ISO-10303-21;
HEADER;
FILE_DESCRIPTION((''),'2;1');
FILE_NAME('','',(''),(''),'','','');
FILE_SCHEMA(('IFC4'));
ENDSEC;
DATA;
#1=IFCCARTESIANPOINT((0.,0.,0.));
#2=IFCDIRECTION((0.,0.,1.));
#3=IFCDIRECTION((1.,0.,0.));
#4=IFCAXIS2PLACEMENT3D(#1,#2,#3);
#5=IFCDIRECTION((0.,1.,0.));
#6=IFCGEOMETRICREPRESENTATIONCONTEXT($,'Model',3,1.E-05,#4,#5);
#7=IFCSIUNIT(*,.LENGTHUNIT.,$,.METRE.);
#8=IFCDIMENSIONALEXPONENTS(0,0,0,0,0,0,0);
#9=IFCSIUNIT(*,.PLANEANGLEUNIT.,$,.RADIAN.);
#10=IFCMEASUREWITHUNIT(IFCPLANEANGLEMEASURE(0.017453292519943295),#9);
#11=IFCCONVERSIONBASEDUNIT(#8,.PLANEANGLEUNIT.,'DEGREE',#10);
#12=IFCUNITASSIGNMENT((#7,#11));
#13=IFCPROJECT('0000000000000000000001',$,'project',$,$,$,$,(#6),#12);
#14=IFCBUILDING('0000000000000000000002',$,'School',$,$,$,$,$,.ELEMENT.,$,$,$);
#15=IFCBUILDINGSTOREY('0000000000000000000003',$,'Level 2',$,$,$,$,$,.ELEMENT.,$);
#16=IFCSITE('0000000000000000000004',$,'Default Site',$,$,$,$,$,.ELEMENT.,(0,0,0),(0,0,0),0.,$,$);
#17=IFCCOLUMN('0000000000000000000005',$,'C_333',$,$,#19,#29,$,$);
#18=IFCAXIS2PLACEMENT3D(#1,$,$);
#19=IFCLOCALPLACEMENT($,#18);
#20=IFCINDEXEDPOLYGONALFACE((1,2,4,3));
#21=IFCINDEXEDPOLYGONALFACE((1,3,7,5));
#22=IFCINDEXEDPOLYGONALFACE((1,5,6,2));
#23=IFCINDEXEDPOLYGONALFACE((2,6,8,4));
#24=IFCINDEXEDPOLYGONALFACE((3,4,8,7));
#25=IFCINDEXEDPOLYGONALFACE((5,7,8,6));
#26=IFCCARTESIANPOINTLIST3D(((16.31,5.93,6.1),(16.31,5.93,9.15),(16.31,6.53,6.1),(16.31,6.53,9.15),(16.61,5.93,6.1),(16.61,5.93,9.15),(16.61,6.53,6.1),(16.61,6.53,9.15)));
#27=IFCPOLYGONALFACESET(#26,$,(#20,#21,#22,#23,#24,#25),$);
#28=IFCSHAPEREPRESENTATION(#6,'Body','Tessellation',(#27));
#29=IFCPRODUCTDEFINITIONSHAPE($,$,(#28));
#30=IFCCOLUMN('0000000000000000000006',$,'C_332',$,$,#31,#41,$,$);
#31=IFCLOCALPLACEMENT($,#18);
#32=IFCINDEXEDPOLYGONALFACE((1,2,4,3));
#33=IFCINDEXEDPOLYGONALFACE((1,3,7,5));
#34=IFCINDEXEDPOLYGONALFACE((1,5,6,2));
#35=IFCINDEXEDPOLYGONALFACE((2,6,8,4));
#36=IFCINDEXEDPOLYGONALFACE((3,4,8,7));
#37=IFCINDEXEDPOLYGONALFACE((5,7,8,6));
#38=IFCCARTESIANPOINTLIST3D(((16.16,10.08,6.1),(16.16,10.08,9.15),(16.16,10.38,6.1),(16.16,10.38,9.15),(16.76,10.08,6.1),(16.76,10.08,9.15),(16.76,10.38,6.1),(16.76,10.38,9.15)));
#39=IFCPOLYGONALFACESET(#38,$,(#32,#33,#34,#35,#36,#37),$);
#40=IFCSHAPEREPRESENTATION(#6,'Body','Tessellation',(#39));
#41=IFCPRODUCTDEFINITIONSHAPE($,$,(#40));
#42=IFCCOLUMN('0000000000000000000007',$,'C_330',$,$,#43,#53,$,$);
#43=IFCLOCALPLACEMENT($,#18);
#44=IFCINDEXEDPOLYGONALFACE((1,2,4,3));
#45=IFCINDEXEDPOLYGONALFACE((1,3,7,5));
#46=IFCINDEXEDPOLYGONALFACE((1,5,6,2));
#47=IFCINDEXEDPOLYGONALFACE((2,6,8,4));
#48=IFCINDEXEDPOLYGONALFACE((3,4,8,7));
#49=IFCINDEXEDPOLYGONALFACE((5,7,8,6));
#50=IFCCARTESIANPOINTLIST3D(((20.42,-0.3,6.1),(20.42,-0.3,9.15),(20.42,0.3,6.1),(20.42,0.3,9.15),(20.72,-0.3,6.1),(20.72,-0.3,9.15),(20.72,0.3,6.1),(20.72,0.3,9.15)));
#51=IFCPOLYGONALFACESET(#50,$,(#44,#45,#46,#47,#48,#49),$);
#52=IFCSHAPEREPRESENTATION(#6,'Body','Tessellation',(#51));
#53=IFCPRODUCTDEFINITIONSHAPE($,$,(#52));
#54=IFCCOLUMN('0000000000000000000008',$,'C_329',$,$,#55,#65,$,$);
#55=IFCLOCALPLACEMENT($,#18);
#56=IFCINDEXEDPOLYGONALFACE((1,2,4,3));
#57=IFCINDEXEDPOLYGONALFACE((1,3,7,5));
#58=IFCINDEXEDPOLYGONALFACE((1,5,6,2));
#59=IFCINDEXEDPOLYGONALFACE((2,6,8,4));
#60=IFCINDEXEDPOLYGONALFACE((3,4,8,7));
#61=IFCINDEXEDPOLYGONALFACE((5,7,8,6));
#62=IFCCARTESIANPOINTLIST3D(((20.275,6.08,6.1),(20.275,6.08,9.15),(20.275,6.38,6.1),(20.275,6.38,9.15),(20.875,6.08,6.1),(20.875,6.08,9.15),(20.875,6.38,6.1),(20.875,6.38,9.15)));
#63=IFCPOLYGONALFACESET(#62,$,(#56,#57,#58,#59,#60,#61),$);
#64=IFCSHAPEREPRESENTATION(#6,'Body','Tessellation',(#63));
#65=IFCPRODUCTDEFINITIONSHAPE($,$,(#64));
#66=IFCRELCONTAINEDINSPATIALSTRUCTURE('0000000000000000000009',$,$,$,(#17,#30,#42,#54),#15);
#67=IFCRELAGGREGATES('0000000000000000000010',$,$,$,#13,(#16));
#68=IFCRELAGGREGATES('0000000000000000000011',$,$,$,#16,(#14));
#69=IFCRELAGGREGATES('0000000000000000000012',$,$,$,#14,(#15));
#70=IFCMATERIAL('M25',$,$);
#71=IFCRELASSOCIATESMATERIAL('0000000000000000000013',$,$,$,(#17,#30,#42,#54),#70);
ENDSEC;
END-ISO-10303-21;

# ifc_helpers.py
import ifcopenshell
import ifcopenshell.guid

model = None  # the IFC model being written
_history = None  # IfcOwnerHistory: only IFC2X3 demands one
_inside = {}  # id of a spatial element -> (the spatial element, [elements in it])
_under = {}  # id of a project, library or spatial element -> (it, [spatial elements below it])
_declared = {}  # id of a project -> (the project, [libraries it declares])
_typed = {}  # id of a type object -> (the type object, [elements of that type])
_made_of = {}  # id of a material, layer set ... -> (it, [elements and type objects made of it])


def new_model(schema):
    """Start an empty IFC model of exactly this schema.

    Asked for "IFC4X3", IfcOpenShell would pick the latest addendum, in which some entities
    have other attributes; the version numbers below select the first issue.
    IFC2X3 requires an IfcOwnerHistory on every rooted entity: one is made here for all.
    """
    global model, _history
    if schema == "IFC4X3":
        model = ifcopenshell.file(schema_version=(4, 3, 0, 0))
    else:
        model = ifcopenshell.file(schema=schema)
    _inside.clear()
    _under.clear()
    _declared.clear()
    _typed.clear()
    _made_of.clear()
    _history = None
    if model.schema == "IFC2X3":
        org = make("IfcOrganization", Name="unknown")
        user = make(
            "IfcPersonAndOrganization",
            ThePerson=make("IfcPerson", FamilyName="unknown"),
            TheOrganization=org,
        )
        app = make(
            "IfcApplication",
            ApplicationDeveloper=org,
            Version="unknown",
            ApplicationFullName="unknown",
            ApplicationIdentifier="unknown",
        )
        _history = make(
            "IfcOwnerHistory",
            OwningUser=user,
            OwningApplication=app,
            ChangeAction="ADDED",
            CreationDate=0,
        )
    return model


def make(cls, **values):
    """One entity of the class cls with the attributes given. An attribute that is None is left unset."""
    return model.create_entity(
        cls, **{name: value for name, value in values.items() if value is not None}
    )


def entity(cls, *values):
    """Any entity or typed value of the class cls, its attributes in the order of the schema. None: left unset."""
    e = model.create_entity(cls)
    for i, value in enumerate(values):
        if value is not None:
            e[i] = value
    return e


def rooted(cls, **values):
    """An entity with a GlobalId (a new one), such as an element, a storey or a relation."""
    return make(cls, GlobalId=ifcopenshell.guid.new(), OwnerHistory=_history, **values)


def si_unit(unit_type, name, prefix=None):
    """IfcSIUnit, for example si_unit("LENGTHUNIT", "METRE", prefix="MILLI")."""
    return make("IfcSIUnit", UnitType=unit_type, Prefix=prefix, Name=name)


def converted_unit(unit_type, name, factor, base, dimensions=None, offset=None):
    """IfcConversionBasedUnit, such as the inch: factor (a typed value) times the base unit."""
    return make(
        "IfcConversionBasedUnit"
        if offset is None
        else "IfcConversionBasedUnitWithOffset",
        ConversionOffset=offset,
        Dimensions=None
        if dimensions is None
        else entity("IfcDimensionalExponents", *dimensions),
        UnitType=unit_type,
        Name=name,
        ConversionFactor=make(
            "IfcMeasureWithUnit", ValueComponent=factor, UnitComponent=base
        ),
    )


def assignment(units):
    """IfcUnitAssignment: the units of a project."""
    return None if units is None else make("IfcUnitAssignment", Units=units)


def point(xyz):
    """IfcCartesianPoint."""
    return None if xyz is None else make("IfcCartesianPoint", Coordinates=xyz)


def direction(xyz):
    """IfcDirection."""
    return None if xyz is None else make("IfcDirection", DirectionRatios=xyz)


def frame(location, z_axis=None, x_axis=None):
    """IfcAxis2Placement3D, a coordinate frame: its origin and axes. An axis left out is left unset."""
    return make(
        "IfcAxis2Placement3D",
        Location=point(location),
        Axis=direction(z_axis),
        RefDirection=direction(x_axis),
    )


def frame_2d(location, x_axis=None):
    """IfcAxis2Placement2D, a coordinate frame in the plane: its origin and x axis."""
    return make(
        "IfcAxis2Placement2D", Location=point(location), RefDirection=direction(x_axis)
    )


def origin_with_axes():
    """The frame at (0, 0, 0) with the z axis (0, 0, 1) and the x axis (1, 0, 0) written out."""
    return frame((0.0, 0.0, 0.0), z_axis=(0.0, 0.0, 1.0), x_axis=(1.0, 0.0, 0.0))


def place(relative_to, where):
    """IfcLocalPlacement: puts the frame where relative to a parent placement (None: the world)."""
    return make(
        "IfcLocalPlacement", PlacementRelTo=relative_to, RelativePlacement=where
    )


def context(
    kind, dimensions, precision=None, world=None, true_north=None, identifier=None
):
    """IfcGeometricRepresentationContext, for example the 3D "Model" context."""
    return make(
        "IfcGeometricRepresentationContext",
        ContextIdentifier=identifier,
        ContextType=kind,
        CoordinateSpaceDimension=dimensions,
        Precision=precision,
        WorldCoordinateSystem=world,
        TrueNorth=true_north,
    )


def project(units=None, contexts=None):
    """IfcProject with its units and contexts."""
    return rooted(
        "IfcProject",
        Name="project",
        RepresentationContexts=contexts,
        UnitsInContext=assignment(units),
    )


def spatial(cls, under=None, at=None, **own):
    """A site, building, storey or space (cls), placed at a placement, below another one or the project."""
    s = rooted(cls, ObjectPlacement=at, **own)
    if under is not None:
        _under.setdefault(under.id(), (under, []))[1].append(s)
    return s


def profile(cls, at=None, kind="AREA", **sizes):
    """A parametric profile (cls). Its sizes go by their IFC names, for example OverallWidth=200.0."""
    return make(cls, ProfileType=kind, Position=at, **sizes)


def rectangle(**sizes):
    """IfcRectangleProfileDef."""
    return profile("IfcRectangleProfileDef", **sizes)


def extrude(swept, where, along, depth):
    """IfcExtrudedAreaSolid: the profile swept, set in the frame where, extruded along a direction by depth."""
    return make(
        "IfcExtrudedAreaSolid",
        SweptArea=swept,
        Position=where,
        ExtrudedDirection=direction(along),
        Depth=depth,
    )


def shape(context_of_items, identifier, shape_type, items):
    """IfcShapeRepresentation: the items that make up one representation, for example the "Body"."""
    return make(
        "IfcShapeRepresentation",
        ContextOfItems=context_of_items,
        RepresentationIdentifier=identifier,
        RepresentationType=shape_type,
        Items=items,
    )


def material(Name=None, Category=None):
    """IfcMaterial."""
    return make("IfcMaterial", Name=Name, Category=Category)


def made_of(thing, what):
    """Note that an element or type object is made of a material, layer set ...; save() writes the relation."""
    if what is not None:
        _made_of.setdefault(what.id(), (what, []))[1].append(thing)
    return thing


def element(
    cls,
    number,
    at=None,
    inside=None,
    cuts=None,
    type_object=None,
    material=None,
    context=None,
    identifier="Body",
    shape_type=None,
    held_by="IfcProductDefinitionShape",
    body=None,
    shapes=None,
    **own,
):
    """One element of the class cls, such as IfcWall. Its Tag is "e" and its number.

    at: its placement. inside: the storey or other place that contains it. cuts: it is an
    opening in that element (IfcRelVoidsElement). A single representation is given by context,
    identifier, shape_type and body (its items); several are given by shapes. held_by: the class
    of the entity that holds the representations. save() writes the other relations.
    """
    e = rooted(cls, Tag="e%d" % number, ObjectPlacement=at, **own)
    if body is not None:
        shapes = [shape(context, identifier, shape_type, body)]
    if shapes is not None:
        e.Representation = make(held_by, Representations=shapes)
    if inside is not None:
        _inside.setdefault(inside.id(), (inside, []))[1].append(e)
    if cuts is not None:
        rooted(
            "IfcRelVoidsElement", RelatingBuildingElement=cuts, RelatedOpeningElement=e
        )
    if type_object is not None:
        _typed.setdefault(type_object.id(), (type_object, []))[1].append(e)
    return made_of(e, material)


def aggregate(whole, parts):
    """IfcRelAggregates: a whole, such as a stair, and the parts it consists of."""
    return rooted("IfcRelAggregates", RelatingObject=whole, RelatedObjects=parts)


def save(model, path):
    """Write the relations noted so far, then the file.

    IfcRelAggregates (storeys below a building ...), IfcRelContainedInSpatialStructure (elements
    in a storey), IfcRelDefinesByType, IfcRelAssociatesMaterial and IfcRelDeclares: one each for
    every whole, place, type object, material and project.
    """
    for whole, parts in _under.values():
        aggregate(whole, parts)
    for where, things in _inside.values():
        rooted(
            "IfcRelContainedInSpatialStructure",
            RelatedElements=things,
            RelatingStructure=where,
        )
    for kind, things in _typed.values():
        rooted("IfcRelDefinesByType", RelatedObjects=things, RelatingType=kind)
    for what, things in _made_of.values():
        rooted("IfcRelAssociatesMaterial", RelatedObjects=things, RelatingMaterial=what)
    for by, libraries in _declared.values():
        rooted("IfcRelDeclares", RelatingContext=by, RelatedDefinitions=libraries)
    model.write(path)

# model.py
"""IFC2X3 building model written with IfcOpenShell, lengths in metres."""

from ifc_helpers import new_model, entity, si_unit, converted_unit, direction, frame, frame_2d, origin_with_axes, place, context, project, spatial, rectangle, extrude, material, element, save


model = new_model("IFC2X3")

# Units and contexts
model_context = context("Model", 3, precision=1e-05, world=origin_with_axes(), true_north=direction((0.0, 1.0, 0.0)))
ifc_project = project(units=[si_unit("LENGTHUNIT", "METRE"), converted_unit("PLANEANGLEUNIT", "DEGREE", entity("IfcPlaneAngleMeasure", 0.017453292519943295), si_unit("PLANEANGLEUNIT", "RADIAN"), dimensions=[0, 0, 0, 0, 0, 0, 0])], contexts=[model_context])

# Site, building, storey
site = spatial("IfcSite", under=ifc_project, Name="Default Site", CompositionType="ELEMENT", RefLatitude=(0, 0, 0), RefLongitude=(0, 0, 0), RefElevation=0.0)
building = spatial("IfcBuilding", under=site, Name="School", CompositionType="ELEMENT")
storey = spatial("IfcBuildingStorey", under=building, Name="Level 2", CompositionType="ELEMENT")

# Columns
ifc_material = material(Name="M25")
placement = place(None, origin_with_axes())
element("IfcColumn", 1, at=placement, inside=storey, material=ifc_material, Name="C_333", context=model_context, shape_type="SweptSolid", body=[
    extrude(rectangle(XDim=0.3, YDim=0.6, at=frame_2d((0.0, 0.0), x_axis=(1.0, 0.0, 0.0))), frame((16.46, 6.23, 6.1), z_axis=(0.0, 0.0, 1.0), x_axis=(1.0, 0.0, 0.0)), (0.0, 0.0, 1.0), 3.05),
])
element("IfcColumn", 2, at=placement, inside=storey, material=ifc_material, Name="C_332", context=model_context, shape_type="SweptSolid", body=[
    extrude(rectangle(XDim=0.6, YDim=0.3, at=frame_2d((0.0, 0.0), x_axis=(1.0, 0.0, 0.0))), frame((16.46, 10.23, 6.1), z_axis=(0.0, 0.0, 1.0), x_axis=(1.0, 0.0, 0.0)), (0.0, 0.0, 1.0), 3.05),
])
element("IfcColumn", 3, at=placement, inside=storey, material=ifc_material, Name="C_330", context=model_context, shape_type="SweptSolid", body=[
    extrude(rectangle(XDim=0.3, YDim=0.6, at=frame_2d((0.0, 0.0), x_axis=(1.0, 0.0, 0.0))), frame((20.57, 0.0, 6.1), z_axis=(0.0, 0.0, 1.0), x_axis=(1.0, 0.0, 0.0)), (0.0, 0.0, 1.0), 3.05),
])
element("IfcColumn", 4, at=placement, inside=storey, material=ifc_material, Name="C_329", context=model_context, shape_type="SweptSolid", body=[
    extrude(rectangle(XDim=0.6, YDim=0.3, at=frame_2d((0.0, 0.0), x_axis=(1.0, 0.0, 0.0))), frame((20.575, 6.23, 6.1), z_axis=(0.0, 0.0, 1.0), x_axis=(1.0, 0.0, 0.0)), (0.0, 0.0, 1.0), 3.05),
])

save(model, "model.ifc")
